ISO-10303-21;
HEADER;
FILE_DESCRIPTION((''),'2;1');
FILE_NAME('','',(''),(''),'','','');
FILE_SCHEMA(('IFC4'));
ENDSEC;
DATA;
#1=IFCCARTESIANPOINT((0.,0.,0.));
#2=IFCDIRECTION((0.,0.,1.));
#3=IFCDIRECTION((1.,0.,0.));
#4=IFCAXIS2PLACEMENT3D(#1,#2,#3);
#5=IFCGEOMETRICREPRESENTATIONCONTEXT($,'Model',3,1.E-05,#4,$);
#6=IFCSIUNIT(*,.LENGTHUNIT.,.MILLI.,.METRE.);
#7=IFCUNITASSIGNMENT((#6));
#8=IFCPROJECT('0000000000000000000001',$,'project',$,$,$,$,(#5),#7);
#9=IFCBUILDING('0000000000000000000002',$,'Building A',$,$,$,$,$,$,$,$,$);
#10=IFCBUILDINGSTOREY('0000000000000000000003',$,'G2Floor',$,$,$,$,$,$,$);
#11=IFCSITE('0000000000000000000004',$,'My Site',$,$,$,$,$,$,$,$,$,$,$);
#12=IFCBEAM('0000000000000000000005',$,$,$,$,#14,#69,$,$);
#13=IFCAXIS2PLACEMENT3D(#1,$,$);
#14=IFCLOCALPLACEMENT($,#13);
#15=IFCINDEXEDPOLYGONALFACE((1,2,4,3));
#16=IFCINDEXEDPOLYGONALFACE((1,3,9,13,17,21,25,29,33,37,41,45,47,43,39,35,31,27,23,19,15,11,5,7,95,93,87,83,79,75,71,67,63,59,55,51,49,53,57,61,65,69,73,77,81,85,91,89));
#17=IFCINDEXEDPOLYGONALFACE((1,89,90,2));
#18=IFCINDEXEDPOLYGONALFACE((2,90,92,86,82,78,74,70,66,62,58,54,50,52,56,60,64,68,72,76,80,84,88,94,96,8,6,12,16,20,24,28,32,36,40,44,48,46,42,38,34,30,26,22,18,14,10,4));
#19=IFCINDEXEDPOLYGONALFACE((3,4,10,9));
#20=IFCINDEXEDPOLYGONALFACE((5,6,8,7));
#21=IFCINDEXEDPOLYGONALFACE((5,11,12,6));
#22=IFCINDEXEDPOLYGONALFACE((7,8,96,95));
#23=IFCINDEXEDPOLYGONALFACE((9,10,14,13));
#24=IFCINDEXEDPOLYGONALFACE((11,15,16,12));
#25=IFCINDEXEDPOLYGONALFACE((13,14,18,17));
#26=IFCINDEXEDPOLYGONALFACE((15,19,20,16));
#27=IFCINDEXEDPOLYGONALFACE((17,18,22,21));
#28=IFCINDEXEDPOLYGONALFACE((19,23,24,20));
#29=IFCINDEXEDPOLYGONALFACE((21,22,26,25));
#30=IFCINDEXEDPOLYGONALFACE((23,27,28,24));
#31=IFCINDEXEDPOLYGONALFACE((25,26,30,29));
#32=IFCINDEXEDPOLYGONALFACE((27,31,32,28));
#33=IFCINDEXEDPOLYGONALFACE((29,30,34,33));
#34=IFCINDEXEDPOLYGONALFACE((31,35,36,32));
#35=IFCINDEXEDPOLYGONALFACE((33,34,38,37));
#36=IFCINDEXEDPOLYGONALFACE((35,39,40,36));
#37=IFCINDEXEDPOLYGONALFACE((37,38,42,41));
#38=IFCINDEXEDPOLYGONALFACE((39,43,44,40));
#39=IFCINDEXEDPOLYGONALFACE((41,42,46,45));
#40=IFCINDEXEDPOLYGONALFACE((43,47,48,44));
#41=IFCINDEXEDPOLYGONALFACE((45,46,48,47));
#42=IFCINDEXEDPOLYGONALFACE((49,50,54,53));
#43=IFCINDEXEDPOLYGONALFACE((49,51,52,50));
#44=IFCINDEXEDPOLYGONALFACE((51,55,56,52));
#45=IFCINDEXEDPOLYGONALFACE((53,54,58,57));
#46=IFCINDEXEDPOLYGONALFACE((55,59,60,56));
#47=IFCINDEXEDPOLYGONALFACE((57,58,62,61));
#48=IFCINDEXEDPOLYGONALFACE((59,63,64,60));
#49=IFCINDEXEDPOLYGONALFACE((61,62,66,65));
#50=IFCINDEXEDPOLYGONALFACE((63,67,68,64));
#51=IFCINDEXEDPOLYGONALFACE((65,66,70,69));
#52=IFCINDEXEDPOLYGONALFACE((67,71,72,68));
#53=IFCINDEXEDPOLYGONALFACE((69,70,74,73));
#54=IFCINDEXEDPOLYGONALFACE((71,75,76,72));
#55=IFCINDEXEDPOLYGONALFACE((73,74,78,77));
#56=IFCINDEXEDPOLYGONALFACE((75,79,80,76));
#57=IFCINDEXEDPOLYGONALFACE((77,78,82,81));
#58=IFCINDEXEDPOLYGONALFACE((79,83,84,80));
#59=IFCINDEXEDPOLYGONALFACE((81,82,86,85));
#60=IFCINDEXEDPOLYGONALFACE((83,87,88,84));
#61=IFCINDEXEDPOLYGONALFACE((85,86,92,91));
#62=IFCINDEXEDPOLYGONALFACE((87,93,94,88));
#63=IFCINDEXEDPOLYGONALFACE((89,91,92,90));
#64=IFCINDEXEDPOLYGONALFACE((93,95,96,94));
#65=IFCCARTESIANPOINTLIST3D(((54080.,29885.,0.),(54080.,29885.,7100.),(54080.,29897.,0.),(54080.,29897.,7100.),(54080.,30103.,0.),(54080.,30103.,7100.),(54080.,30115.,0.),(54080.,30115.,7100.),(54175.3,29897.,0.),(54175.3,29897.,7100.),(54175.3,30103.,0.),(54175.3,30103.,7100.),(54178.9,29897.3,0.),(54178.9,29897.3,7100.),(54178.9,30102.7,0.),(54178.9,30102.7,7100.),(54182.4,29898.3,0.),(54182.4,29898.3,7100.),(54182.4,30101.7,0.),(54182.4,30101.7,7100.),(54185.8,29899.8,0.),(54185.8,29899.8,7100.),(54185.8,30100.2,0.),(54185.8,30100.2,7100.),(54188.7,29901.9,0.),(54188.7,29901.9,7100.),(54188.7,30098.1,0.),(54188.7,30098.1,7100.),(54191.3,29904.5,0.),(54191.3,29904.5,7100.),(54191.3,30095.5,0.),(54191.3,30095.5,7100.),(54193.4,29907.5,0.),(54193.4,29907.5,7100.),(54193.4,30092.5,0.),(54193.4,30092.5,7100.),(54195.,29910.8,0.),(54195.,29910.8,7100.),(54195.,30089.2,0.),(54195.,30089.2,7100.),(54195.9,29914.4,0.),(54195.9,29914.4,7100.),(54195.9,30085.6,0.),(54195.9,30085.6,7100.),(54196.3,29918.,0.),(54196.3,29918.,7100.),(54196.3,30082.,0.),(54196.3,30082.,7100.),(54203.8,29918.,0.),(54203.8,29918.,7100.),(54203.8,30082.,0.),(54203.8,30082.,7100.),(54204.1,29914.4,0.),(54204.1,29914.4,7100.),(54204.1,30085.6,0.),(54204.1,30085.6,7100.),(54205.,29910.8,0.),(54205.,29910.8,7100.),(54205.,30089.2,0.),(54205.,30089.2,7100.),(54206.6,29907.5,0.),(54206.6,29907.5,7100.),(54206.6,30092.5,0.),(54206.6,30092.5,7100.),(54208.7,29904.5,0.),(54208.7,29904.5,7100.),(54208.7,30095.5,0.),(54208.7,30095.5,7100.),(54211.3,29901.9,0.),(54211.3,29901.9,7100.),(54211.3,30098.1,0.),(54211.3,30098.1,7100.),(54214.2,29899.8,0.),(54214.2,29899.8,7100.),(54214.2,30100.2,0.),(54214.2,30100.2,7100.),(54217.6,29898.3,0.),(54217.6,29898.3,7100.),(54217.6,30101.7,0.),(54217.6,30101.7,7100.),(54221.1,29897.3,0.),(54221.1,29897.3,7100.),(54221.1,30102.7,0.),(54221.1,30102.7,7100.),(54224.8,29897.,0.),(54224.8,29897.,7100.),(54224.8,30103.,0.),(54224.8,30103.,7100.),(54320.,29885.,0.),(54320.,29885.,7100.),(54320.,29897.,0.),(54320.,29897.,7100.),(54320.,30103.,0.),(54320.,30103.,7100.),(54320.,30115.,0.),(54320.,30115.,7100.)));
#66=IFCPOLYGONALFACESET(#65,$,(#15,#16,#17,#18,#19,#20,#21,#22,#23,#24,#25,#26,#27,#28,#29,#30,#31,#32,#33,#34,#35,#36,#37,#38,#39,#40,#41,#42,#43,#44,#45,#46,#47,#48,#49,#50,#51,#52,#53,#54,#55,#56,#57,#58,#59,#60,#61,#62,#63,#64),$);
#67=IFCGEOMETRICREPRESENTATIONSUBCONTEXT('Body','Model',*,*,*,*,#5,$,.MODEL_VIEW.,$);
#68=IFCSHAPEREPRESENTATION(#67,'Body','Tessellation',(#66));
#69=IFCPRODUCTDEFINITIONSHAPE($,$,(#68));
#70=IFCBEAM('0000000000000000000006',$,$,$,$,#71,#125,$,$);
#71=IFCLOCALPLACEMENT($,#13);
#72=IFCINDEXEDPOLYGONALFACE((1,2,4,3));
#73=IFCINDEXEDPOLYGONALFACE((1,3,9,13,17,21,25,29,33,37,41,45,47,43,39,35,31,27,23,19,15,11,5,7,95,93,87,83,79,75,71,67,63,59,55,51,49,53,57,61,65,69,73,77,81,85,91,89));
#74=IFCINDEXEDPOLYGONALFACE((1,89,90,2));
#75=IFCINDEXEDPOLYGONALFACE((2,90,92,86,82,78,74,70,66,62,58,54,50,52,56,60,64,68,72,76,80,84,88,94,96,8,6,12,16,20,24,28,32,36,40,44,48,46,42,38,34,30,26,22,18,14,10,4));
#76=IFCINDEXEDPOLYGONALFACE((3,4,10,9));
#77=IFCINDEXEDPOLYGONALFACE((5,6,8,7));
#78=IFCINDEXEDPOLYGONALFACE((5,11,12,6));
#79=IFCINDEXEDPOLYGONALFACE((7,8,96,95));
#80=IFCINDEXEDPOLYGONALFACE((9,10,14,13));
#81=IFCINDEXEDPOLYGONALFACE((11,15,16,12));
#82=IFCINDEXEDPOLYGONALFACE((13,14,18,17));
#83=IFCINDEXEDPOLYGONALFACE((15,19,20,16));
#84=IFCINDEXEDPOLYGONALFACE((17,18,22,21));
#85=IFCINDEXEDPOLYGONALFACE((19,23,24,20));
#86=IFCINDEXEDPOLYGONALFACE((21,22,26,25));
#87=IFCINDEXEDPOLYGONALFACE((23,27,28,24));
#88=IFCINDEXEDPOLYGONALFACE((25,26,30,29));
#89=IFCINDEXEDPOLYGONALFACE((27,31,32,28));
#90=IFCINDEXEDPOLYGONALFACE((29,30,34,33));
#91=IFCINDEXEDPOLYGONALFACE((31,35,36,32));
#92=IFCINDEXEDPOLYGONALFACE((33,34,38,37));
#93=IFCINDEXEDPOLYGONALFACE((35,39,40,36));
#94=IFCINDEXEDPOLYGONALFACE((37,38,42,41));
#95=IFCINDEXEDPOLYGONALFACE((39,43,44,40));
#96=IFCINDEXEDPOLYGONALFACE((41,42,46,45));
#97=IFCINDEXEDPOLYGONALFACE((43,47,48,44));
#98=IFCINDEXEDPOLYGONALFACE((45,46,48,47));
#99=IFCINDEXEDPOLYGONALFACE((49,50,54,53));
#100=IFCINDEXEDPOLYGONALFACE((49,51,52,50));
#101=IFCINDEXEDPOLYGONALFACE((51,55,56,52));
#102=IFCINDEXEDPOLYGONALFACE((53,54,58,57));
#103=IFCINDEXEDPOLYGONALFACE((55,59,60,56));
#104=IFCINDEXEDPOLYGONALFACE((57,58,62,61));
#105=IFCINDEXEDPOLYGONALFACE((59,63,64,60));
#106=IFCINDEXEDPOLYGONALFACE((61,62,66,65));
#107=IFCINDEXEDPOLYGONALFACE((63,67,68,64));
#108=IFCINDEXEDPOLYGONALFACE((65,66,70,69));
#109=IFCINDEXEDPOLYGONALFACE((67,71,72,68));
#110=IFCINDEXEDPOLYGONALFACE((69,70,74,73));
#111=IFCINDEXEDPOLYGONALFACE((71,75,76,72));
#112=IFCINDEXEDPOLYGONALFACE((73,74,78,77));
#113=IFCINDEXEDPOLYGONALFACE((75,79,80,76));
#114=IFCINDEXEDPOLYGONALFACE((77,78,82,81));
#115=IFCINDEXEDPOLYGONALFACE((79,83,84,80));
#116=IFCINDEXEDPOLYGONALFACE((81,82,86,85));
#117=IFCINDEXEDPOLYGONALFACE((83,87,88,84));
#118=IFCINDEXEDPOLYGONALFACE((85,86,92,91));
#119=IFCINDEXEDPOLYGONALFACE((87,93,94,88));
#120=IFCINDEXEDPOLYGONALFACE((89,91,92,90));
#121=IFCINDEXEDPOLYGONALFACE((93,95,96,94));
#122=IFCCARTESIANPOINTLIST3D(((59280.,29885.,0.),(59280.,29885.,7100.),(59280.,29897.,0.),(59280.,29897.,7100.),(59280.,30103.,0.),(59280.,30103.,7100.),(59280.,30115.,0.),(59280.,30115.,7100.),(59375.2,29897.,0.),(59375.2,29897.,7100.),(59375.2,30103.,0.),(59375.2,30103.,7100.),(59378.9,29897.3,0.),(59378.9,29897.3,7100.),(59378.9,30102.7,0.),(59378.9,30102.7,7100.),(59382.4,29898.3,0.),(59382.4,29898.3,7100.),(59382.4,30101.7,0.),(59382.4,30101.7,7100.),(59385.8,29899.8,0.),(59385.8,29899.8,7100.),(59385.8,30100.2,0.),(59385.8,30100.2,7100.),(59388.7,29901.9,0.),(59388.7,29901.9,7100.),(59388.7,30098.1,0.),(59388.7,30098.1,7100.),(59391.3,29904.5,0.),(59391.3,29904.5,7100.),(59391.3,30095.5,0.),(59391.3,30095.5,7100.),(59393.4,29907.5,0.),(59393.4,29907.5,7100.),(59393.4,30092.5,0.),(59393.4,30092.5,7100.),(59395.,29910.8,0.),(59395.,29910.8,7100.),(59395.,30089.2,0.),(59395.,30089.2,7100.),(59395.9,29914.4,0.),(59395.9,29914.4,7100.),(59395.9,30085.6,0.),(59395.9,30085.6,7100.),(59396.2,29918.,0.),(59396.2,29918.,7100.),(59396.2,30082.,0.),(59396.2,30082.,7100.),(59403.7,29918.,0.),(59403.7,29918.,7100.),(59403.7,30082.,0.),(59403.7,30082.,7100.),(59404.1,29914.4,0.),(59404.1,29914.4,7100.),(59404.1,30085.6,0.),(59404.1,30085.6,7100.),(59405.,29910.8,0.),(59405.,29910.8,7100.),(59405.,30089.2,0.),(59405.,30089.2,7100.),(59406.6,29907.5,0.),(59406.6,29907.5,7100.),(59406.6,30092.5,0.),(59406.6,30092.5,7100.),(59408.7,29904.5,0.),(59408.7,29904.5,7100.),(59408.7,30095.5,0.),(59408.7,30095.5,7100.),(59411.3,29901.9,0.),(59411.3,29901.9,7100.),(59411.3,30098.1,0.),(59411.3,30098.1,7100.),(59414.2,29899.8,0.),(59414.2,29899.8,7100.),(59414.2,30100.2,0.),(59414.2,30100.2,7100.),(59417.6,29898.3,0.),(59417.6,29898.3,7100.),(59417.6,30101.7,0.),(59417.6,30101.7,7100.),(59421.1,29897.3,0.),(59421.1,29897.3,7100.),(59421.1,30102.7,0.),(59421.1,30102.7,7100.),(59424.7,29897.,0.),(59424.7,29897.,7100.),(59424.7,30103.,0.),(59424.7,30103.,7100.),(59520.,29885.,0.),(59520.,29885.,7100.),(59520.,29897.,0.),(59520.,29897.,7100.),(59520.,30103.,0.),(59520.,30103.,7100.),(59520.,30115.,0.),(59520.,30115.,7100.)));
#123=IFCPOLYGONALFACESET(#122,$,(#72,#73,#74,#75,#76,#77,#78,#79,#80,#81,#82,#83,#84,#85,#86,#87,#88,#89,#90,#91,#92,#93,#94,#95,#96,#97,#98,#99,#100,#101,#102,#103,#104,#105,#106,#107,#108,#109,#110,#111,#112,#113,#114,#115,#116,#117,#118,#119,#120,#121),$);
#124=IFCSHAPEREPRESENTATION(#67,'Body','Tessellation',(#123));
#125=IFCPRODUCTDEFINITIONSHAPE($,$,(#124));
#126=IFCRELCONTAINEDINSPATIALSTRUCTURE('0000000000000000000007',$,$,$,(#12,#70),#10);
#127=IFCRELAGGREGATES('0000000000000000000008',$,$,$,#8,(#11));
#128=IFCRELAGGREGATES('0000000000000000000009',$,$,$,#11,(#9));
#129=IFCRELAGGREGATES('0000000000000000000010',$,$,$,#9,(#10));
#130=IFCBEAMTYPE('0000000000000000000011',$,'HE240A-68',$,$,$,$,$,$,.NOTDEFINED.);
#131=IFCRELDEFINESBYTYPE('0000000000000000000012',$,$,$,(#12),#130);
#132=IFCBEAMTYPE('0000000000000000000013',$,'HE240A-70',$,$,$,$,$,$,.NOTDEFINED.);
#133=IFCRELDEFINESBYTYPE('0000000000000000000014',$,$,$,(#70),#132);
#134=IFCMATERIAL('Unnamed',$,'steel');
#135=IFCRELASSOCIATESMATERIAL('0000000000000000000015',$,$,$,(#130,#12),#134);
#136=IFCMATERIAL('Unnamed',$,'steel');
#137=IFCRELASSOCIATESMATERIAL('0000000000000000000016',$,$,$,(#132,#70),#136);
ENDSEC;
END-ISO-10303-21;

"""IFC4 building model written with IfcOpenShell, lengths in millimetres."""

from ifc_helpers import new_model, si_unit, frame, origin_with_axes, place, context, subcontext, project, spatial, polyline, outline, extrude, material, material_profile, profile_set, profile_usage, type_object, element, save


model = new_model("IFC4")

# Units and contexts
model_context = context("Model", 3, precision=1e-05, world=origin_with_axes())
body_context = subcontext(model_context, "Body", "Model", "MODEL_VIEW")
ifc_project = project(units=[si_unit("LENGTHUNIT", "METRE", prefix="MILLI")], contexts=[model_context])

# Site, building, storey
site = spatial("IfcSite", under=ifc_project, Name="My Site")
building = spatial("IfcBuilding", under=site, Name="Building A")
storey = spatial("IfcBuildingStorey", under=building, Name="G2Floor")

# Beams
ifc_material_1 = material(Name="Unnamed", Category="steel")
ifc_material_profile_1 = material_profile(ifc_material_1, outline(polyline([(120.0, -115.0), (120.0, -103.0), (120.0, -103.0), (24.8, -103.0), (24.8, -103.0), (21.1, -102.7), (21.1, -102.7), (17.6, -101.7), (17.6, -101.7), (14.2, -100.2), (14.2, -100.2), (11.3, -98.1), (11.3, -98.1), (8.7, -95.5), (8.7, -95.5), (6.6, -92.5), (6.6, -92.5), (5.0, -89.2), (5.0, -89.2), (4.1, -85.6), (4.1, -85.6), (3.8, -82.0), (3.8, -82.0), (3.8, 82.0), (3.8, 82.0), (4.1, 85.6), (4.1, 85.6), (5.0, 89.2), (5.0, 89.2), (6.6, 92.5), (6.6, 92.5), (8.7, 95.5), (8.7, 95.5), (11.3, 98.1), (11.3, 98.1), (14.2, 100.2), (14.2, 100.2), (17.6, 101.7), (17.6, 101.7), (21.1, 102.7), (21.1, 102.7), (24.8, 103.0), (24.8, 103.0), (120.0, 103.0), (120.0, 103.0), (120.0, 115.0), (120.0, 115.0), (-120.0, 115.0), (-120.0, 115.0), (-120.0, 103.0), (-120.0, 103.0), (-24.8, 103.0), (-24.8, 103.0), (-21.1, 102.7), (-21.1, 102.7), (-17.6, 101.7), (-17.6, 101.7), (-14.2, 100.2), (-14.2, 100.2), (-11.3, 98.1), (-11.3, 98.1), (-8.7, 95.5), (-8.7, 95.5), (-6.6, 92.5), (-6.6, 92.5), (-5.0, 89.2), (-5.0, 89.2), (-4.1, 85.6), (-4.1, 85.6), (-3.8, 82.0), (-3.8, 82.0), (-3.8, -82.0), (-3.8, -82.0), (-4.1, -85.6), (-4.1, -85.6), (-5.0, -89.2), (-5.0, -89.2), (-6.6, -92.5), (-6.6, -92.5), (-8.7, -95.5), (-8.7, -95.5), (-11.3, -98.1), (-11.3, -98.1), (-14.2, -100.2), (-14.2, -100.2), (-17.6, -101.7), (-17.6, -101.7), (-21.1, -102.7), (-21.1, -102.7), (-24.8, -103.0), (-24.8, -103.0), (-120.0, -103.0), (-120.0, -103.0), (-120.0, -115.0), (-120.0, -115.0), (120.0, -115.0)])))
ifc_profile_set_1 = profile_set([ifc_material_profile_1], Name="HE240A-68")
ifc_profile_usage_1 = profile_usage(ifc_profile_set_1)
beam_type_1 = type_object("IfcBeamType", Name="HE240A-68", PredefinedType="NOTDEFINED", material=ifc_profile_set_1)
beam_1_placement = place(None, frame((54200.0, 30000.0, 0.0), z_axis=(0.0, 0.0, 1.0), x_axis=(1.0, 0.0, 0.0)))
element("IfcBeam", 1, at=beam_1_placement, inside=storey, type_object=beam_type_1, material=ifc_profile_usage_1, context=body_context, shape_type="SweptSolid", body=[
    extrude(outline(polyline([(120.0, -115.0), (120.0, -103.0), (120.0, -103.0), (24.8, -103.0), (24.8, -103.0), (21.1, -102.7), (21.1, -102.7), (17.6, -101.7), (17.6, -101.7), (14.2, -100.2), (14.2, -100.2), (11.3, -98.1), (11.3, -98.1), (8.7, -95.5), (8.7, -95.5), (6.6, -92.5), (6.6, -92.5), (5.0, -89.2), (5.0, -89.2), (4.1, -85.6), (4.1, -85.6), (3.8, -82.0), (3.8, -82.0), (3.8, 82.0), (3.8, 82.0), (4.1, 85.6), (4.1, 85.6), (5.0, 89.2), (5.0, 89.2), (6.6, 92.5), (6.6, 92.5), (8.7, 95.5), (8.7, 95.5), (11.3, 98.1), (11.3, 98.1), (14.2, 100.2), (14.2, 100.2), (17.6, 101.7), (17.6, 101.7), (21.1, 102.7), (21.1, 102.7), (24.8, 103.0), (24.8, 103.0), (120.0, 103.0), (120.0, 103.0), (120.0, 115.0), (120.0, 115.0), (-120.0, 115.0), (-120.0, 115.0), (-120.0, 103.0), (-120.0, 103.0), (-24.8, 103.0), (-24.8, 103.0), (-21.1, 102.7), (-21.1, 102.7), (-17.6, 101.7), (-17.6, 101.7), (-14.2, 100.2), (-14.2, 100.2), (-11.3, 98.1), (-11.3, 98.1), (-8.7, 95.5), (-8.7, 95.5), (-6.6, 92.5), (-6.6, 92.5), (-5.0, 89.2), (-5.0, 89.2), (-4.1, 85.6), (-4.1, 85.6), (-3.8, 82.0), (-3.8, 82.0), (-3.8, -82.0), (-3.8, -82.0), (-4.1, -85.6), (-4.1, -85.6), (-5.0, -89.2), (-5.0, -89.2), (-6.6, -92.5), (-6.6, -92.5), (-8.7, -95.5), (-8.7, -95.5), (-11.3, -98.1), (-11.3, -98.1), (-14.2, -100.2), (-14.2, -100.2), (-17.6, -101.7), (-17.6, -101.7), (-21.1, -102.7), (-21.1, -102.7), (-24.8, -103.0), (-24.8, -103.0), (-120.0, -103.0), (-120.0, -103.0), (-120.0, -115.0), (-120.0, -115.0), (120.0, -115.0)])), origin_with_axes(), (0.0, 0.0, 1.0), 7100.0),
])
ifc_material_2 = material(Name="Unnamed", Category="steel")
ifc_material_profile_2 = material_profile(ifc_material_2, outline(polyline([(120.0, -115.0), (120.0, -103.0), (120.0, -103.0), (24.8, -103.0), (24.8, -103.0), (21.1, -102.7), (21.1, -102.7), (17.6, -101.7), (17.6, -101.7), (14.2, -100.2), (14.2, -100.2), (11.3, -98.1), (11.3, -98.1), (8.7, -95.5), (8.7, -95.5), (6.6, -92.5), (6.6, -92.5), (5.0, -89.2), (5.0, -89.2), (4.1, -85.6), (4.1, -85.6), (3.8, -82.0), (3.8, -82.0), (3.8, 82.0), (3.8, 82.0), (4.1, 85.6), (4.1, 85.6), (5.0, 89.2), (5.0, 89.2), (6.6, 92.5), (6.6, 92.5), (8.7, 95.5), (8.7, 95.5), (11.3, 98.1), (11.3, 98.1), (14.2, 100.2), (14.2, 100.2), (17.6, 101.7), (17.6, 101.7), (21.1, 102.7), (21.1, 102.7), (24.8, 103.0), (24.8, 103.0), (120.0, 103.0), (120.0, 103.0), (120.0, 115.0), (120.0, 115.0), (-120.0, 115.0), (-120.0, 115.0), (-120.0, 103.0), (-120.0, 103.0), (-24.8, 103.0), (-24.8, 103.0), (-21.1, 102.7), (-21.1, 102.7), (-17.6, 101.7), (-17.6, 101.7), (-14.2, 100.2), (-14.2, 100.2), (-11.3, 98.1), (-11.3, 98.1), (-8.7, 95.5), (-8.7, 95.5), (-6.6, 92.5), (-6.6, 92.5), (-5.0, 89.2), (-5.0, 89.2), (-4.1, 85.6), (-4.1, 85.6), (-3.8, 82.0), (-3.8, 82.0), (-3.8, -82.0), (-3.8, -82.0), (-4.1, -85.6), (-4.1, -85.6), (-5.0, -89.2), (-5.0, -89.2), (-6.6, -92.5), (-6.6, -92.5), (-8.7, -95.5), (-8.7, -95.5), (-11.3, -98.1), (-11.3, -98.1), (-14.2, -100.2), (-14.2, -100.2), (-17.6, -101.7), (-17.6, -101.7), (-21.1, -102.7), (-21.1, -102.7), (-24.8, -103.0), (-24.8, -103.0), (-120.0, -103.0), (-120.0, -103.0), (-120.0, -115.0), (-120.0, -115.0), (120.0, -115.0)])))
ifc_profile_set_2 = profile_set([ifc_material_profile_2], Name="HE240A-70")
ifc_profile_usage_2 = profile_usage(ifc_profile_set_2)
beam_type_2 = type_object("IfcBeamType", Name="HE240A-70", PredefinedType="NOTDEFINED", material=ifc_profile_set_2)
beam_2_placement = place(None, frame((59400.0, 30000.0, 0.0), z_axis=(0.0, 0.0, 1.0), x_axis=(1.0, 0.0, 0.0)))
element("IfcBeam", 2, at=beam_2_placement, inside=storey, type_object=beam_type_2, material=ifc_profile_usage_2, context=body_context, shape_type="SweptSolid", body=[
    extrude(outline(polyline([(120.0, -115.0), (120.0, -103.0), (120.0, -103.0), (24.8, -103.0), (24.8, -103.0), (21.1, -102.7), (21.1, -102.7), (17.6, -101.7), (17.6, -101.7), (14.2, -100.2), (14.2, -100.2), (11.3, -98.1), (11.3, -98.1), (8.7, -95.5), (8.7, -95.5), (6.6, -92.5), (6.6, -92.5), (5.0, -89.2), (5.0, -89.2), (4.1, -85.6), (4.1, -85.6), (3.8, -82.0), (3.8, -82.0), (3.8, 82.0), (3.8, 82.0), (4.1, 85.6), (4.1, 85.6), (5.0, 89.2), (5.0, 89.2), (6.6, 92.5), (6.6, 92.5), (8.7, 95.5), (8.7, 95.5), (11.3, 98.1), (11.3, 98.1), (14.2, 100.2), (14.2, 100.2), (17.6, 101.7), (17.6, 101.7), (21.1, 102.7), (21.1, 102.7), (24.8, 103.0), (24.8, 103.0), (120.0, 103.0), (120.0, 103.0), (120.0, 115.0), (120.0, 115.0), (-120.0, 115.0), (-120.0, 115.0), (-120.0, 103.0), (-120.0, 103.0), (-24.8, 103.0), (-24.8, 103.0), (-21.1, 102.7), (-21.1, 102.7), (-17.6, 101.7), (-17.6, 101.7), (-14.2, 100.2), (-14.2, 100.2), (-11.3, 98.1), (-11.3, 98.1), (-8.7, 95.5), (-8.7, 95.5), (-6.6, 92.5), (-6.6, 92.5), (-5.0, 89.2), (-5.0, 89.2), (-4.1, 85.6), (-4.1, 85.6), (-3.8, 82.0), (-3.8, 82.0), (-3.8, -82.0), (-3.8, -82.0), (-4.1, -85.6), (-4.1, -85.6), (-5.0, -89.2), (-5.0, -89.2), (-6.6, -92.5), (-6.6, -92.5), (-8.7, -95.5), (-8.7, -95.5), (-11.3, -98.1), (-11.3, -98.1), (-14.2, -100.2), (-14.2, -100.2), (-17.6, -101.7), (-17.6, -101.7), (-21.1, -102.7), (-21.1, -102.7), (-24.8, -103.0), (-24.8, -103.0), (-120.0, -103.0), (-120.0, -103.0), (-120.0, -115.0), (-120.0, -115.0), (120.0, -115.0)])), origin_with_axes(), (0.0, 0.0, 1.0), 7100.0),
])

save(model, "model.ifc")
